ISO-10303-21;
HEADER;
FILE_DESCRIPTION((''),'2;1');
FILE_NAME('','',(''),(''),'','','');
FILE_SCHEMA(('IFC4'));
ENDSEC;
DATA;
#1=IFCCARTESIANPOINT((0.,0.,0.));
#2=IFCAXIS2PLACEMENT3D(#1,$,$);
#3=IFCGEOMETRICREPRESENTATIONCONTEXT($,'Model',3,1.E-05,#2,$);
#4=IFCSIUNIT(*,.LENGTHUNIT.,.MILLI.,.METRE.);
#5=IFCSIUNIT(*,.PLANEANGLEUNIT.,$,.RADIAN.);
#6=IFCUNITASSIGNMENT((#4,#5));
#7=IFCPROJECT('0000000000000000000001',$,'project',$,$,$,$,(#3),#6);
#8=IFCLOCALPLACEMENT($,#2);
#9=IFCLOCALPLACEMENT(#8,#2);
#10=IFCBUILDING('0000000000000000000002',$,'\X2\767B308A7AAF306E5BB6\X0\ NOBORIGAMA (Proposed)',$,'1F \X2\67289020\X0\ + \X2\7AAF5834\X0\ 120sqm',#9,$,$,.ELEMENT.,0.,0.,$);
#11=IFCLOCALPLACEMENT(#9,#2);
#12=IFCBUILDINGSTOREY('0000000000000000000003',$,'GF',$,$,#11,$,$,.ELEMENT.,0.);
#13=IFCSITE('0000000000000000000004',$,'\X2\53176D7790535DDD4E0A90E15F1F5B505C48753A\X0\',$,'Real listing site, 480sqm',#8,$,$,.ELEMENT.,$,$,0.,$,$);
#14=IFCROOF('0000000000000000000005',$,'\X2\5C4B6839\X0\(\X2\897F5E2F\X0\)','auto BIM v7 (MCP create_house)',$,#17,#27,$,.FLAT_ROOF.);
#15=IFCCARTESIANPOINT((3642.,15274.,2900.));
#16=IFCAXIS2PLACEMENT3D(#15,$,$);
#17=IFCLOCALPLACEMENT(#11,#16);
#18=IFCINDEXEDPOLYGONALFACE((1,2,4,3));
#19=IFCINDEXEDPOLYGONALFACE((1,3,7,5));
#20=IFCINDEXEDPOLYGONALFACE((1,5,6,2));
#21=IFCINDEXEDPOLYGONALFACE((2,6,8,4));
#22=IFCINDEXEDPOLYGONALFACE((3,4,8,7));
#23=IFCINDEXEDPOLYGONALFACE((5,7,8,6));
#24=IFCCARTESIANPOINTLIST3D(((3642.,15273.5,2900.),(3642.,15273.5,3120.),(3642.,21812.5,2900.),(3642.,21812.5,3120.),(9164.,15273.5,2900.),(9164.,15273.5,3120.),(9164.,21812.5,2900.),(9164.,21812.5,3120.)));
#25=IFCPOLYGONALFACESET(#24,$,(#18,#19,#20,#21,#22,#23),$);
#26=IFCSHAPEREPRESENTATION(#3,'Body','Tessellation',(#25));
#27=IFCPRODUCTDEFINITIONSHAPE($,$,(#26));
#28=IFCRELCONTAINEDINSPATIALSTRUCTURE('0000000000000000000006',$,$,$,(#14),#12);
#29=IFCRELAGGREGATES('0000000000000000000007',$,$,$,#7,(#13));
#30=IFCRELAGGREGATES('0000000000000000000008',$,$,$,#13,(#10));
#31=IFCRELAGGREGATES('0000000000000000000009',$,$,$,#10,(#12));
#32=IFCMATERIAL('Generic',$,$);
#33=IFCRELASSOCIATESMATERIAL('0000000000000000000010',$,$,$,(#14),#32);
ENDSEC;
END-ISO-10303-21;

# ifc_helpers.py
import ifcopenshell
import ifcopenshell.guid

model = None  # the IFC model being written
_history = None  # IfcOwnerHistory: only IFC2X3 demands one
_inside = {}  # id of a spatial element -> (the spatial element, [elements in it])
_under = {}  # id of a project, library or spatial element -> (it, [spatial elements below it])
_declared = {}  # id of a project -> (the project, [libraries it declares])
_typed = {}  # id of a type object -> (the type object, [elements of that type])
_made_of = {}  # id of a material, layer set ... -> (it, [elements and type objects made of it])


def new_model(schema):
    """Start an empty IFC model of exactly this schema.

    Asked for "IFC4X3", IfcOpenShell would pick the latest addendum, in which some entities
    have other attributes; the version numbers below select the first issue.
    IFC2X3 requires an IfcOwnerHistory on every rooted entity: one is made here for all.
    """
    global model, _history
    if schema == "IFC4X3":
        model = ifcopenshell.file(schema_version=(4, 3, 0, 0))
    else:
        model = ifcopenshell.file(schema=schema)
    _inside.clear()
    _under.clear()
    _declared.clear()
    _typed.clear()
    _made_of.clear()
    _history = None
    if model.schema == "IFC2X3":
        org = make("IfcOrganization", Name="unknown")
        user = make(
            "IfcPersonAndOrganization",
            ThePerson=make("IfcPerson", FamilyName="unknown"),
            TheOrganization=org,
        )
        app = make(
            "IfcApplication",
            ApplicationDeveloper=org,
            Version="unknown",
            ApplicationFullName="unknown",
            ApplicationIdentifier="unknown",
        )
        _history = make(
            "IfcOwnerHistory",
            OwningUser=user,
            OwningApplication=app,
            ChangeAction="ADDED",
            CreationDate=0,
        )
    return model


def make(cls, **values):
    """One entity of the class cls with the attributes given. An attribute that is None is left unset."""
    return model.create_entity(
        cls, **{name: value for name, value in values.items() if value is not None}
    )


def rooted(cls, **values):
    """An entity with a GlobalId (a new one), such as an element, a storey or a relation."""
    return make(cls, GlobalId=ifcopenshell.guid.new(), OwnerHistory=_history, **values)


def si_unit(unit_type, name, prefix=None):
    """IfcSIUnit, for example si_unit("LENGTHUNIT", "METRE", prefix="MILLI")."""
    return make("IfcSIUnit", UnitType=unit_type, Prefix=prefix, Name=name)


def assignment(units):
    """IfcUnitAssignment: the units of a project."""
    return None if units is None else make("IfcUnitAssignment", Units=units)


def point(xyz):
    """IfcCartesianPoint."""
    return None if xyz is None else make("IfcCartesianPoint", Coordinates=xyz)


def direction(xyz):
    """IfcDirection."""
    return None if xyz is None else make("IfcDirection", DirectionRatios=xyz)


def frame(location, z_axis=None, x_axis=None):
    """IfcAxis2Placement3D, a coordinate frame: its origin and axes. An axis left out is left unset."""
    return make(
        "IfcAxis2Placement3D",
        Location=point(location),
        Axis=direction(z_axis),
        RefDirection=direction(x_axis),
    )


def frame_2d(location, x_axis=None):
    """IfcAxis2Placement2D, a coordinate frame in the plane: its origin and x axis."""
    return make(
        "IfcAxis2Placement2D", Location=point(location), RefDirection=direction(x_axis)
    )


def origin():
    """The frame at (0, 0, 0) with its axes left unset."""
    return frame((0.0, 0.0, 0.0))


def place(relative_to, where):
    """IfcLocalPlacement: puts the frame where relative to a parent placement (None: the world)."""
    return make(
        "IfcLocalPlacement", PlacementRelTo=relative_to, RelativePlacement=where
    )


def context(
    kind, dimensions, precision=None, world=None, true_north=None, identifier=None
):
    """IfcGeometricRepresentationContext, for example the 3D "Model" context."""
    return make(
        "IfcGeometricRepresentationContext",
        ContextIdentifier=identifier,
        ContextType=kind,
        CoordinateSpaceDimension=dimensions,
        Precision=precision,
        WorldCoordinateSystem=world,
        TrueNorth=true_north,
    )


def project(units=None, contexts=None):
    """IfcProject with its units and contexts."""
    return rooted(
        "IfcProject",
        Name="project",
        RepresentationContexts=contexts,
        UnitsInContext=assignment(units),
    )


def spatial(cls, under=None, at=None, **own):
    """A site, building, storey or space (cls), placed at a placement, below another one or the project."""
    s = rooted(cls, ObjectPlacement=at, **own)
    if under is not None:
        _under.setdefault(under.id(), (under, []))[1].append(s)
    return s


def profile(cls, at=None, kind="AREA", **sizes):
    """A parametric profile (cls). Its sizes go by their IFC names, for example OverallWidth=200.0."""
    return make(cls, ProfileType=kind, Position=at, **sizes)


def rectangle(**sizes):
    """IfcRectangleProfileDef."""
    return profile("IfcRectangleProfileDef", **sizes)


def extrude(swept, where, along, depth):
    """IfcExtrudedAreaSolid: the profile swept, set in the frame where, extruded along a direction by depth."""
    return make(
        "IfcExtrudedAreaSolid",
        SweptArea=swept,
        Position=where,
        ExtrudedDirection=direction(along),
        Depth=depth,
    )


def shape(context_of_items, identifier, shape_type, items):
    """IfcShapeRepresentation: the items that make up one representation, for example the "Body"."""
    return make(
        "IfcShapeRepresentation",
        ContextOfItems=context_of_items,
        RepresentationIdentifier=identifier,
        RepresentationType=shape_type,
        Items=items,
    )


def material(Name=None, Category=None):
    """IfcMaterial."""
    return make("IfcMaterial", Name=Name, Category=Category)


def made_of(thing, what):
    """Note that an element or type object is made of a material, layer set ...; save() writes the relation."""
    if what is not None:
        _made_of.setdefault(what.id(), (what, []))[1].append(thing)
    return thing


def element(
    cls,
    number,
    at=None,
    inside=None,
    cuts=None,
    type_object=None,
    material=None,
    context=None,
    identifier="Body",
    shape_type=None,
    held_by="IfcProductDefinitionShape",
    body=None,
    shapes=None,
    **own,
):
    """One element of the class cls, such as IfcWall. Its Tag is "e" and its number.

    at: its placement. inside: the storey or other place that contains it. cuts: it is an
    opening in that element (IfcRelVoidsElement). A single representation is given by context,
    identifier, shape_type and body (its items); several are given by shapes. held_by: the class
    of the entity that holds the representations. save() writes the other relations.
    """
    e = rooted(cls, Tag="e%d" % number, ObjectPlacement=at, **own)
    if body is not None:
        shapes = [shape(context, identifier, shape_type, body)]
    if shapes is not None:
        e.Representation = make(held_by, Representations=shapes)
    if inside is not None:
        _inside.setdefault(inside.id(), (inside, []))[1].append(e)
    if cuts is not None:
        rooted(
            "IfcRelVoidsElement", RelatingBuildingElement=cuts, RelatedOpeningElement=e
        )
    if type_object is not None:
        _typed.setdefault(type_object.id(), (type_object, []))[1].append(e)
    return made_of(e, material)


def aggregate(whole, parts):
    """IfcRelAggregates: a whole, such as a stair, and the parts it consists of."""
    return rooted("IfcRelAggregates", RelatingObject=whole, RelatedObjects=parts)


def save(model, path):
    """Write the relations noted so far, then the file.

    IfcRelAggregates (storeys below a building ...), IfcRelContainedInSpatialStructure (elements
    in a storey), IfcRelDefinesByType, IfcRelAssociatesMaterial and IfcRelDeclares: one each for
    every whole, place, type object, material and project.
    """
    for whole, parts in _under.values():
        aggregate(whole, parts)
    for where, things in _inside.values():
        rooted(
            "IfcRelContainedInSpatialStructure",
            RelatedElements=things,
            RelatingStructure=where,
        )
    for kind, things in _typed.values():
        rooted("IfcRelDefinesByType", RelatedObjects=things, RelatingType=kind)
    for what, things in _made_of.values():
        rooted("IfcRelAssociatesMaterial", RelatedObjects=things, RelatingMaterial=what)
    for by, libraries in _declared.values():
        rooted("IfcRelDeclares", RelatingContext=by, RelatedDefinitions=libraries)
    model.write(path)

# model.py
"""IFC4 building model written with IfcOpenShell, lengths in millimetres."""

from ifc_helpers import new_model, si_unit, frame, frame_2d, origin, place, context, project, spatial, rectangle, extrude, material, element, save


model = new_model("IFC4")

# Units and contexts
model_context = context("Model", 3, precision=1e-05, world=origin())
ifc_project = project(units=[si_unit("LENGTHUNIT", "METRE", prefix="MILLI"), si_unit("PLANEANGLEUNIT", "RADIAN")], contexts=[model_context])

# Site, building, storey
site_placement = place(None, origin())
site = spatial("IfcSite", under=ifc_project, at=site_placement, Name="北海道川上郡弟子屈町", ObjectType="Real listing site, 480sqm", CompositionType="ELEMENT", RefElevation=0.0)
building_placement = place(site_placement, origin())
building = spatial("IfcBuilding", under=site, at=building_placement, Name="登り窯の家 NOBORIGAMA (Proposed)", ObjectType="1F 木造 + 窯場 120sqm", CompositionType="ELEMENT", ElevationOfRefHeight=0.0, ElevationOfTerrain=0.0)
storey_placement = place(building_placement, origin())
storey = spatial("IfcBuildingStorey", under=building, at=storey_placement, Name="GF", CompositionType="ELEMENT", Elevation=0.0)

# Shared definitions
ifc_material = material(Name="Generic")

# Roof
roof_1_placement = place(storey_placement, frame((3642.0, 15274.0, 2900.0)))
element("IfcRoof", 1, at=roof_1_placement, inside=storey, material=ifc_material, Name="屋根(西帯)", Description="auto BIM v7 (MCP create_house)", PredefinedType="FLAT_ROOF", context=model_context, shape_type="SweptSolid", body=[
    extrude(rectangle(XDim=5522.0, YDim=6539.0, at=frame_2d((2761.0, 3269.0))), frame((3642.0, 15274.0, 2900.0)), (0.0, 0.0, 1.0), 220.0),
])

save(model, "model.ifc")
